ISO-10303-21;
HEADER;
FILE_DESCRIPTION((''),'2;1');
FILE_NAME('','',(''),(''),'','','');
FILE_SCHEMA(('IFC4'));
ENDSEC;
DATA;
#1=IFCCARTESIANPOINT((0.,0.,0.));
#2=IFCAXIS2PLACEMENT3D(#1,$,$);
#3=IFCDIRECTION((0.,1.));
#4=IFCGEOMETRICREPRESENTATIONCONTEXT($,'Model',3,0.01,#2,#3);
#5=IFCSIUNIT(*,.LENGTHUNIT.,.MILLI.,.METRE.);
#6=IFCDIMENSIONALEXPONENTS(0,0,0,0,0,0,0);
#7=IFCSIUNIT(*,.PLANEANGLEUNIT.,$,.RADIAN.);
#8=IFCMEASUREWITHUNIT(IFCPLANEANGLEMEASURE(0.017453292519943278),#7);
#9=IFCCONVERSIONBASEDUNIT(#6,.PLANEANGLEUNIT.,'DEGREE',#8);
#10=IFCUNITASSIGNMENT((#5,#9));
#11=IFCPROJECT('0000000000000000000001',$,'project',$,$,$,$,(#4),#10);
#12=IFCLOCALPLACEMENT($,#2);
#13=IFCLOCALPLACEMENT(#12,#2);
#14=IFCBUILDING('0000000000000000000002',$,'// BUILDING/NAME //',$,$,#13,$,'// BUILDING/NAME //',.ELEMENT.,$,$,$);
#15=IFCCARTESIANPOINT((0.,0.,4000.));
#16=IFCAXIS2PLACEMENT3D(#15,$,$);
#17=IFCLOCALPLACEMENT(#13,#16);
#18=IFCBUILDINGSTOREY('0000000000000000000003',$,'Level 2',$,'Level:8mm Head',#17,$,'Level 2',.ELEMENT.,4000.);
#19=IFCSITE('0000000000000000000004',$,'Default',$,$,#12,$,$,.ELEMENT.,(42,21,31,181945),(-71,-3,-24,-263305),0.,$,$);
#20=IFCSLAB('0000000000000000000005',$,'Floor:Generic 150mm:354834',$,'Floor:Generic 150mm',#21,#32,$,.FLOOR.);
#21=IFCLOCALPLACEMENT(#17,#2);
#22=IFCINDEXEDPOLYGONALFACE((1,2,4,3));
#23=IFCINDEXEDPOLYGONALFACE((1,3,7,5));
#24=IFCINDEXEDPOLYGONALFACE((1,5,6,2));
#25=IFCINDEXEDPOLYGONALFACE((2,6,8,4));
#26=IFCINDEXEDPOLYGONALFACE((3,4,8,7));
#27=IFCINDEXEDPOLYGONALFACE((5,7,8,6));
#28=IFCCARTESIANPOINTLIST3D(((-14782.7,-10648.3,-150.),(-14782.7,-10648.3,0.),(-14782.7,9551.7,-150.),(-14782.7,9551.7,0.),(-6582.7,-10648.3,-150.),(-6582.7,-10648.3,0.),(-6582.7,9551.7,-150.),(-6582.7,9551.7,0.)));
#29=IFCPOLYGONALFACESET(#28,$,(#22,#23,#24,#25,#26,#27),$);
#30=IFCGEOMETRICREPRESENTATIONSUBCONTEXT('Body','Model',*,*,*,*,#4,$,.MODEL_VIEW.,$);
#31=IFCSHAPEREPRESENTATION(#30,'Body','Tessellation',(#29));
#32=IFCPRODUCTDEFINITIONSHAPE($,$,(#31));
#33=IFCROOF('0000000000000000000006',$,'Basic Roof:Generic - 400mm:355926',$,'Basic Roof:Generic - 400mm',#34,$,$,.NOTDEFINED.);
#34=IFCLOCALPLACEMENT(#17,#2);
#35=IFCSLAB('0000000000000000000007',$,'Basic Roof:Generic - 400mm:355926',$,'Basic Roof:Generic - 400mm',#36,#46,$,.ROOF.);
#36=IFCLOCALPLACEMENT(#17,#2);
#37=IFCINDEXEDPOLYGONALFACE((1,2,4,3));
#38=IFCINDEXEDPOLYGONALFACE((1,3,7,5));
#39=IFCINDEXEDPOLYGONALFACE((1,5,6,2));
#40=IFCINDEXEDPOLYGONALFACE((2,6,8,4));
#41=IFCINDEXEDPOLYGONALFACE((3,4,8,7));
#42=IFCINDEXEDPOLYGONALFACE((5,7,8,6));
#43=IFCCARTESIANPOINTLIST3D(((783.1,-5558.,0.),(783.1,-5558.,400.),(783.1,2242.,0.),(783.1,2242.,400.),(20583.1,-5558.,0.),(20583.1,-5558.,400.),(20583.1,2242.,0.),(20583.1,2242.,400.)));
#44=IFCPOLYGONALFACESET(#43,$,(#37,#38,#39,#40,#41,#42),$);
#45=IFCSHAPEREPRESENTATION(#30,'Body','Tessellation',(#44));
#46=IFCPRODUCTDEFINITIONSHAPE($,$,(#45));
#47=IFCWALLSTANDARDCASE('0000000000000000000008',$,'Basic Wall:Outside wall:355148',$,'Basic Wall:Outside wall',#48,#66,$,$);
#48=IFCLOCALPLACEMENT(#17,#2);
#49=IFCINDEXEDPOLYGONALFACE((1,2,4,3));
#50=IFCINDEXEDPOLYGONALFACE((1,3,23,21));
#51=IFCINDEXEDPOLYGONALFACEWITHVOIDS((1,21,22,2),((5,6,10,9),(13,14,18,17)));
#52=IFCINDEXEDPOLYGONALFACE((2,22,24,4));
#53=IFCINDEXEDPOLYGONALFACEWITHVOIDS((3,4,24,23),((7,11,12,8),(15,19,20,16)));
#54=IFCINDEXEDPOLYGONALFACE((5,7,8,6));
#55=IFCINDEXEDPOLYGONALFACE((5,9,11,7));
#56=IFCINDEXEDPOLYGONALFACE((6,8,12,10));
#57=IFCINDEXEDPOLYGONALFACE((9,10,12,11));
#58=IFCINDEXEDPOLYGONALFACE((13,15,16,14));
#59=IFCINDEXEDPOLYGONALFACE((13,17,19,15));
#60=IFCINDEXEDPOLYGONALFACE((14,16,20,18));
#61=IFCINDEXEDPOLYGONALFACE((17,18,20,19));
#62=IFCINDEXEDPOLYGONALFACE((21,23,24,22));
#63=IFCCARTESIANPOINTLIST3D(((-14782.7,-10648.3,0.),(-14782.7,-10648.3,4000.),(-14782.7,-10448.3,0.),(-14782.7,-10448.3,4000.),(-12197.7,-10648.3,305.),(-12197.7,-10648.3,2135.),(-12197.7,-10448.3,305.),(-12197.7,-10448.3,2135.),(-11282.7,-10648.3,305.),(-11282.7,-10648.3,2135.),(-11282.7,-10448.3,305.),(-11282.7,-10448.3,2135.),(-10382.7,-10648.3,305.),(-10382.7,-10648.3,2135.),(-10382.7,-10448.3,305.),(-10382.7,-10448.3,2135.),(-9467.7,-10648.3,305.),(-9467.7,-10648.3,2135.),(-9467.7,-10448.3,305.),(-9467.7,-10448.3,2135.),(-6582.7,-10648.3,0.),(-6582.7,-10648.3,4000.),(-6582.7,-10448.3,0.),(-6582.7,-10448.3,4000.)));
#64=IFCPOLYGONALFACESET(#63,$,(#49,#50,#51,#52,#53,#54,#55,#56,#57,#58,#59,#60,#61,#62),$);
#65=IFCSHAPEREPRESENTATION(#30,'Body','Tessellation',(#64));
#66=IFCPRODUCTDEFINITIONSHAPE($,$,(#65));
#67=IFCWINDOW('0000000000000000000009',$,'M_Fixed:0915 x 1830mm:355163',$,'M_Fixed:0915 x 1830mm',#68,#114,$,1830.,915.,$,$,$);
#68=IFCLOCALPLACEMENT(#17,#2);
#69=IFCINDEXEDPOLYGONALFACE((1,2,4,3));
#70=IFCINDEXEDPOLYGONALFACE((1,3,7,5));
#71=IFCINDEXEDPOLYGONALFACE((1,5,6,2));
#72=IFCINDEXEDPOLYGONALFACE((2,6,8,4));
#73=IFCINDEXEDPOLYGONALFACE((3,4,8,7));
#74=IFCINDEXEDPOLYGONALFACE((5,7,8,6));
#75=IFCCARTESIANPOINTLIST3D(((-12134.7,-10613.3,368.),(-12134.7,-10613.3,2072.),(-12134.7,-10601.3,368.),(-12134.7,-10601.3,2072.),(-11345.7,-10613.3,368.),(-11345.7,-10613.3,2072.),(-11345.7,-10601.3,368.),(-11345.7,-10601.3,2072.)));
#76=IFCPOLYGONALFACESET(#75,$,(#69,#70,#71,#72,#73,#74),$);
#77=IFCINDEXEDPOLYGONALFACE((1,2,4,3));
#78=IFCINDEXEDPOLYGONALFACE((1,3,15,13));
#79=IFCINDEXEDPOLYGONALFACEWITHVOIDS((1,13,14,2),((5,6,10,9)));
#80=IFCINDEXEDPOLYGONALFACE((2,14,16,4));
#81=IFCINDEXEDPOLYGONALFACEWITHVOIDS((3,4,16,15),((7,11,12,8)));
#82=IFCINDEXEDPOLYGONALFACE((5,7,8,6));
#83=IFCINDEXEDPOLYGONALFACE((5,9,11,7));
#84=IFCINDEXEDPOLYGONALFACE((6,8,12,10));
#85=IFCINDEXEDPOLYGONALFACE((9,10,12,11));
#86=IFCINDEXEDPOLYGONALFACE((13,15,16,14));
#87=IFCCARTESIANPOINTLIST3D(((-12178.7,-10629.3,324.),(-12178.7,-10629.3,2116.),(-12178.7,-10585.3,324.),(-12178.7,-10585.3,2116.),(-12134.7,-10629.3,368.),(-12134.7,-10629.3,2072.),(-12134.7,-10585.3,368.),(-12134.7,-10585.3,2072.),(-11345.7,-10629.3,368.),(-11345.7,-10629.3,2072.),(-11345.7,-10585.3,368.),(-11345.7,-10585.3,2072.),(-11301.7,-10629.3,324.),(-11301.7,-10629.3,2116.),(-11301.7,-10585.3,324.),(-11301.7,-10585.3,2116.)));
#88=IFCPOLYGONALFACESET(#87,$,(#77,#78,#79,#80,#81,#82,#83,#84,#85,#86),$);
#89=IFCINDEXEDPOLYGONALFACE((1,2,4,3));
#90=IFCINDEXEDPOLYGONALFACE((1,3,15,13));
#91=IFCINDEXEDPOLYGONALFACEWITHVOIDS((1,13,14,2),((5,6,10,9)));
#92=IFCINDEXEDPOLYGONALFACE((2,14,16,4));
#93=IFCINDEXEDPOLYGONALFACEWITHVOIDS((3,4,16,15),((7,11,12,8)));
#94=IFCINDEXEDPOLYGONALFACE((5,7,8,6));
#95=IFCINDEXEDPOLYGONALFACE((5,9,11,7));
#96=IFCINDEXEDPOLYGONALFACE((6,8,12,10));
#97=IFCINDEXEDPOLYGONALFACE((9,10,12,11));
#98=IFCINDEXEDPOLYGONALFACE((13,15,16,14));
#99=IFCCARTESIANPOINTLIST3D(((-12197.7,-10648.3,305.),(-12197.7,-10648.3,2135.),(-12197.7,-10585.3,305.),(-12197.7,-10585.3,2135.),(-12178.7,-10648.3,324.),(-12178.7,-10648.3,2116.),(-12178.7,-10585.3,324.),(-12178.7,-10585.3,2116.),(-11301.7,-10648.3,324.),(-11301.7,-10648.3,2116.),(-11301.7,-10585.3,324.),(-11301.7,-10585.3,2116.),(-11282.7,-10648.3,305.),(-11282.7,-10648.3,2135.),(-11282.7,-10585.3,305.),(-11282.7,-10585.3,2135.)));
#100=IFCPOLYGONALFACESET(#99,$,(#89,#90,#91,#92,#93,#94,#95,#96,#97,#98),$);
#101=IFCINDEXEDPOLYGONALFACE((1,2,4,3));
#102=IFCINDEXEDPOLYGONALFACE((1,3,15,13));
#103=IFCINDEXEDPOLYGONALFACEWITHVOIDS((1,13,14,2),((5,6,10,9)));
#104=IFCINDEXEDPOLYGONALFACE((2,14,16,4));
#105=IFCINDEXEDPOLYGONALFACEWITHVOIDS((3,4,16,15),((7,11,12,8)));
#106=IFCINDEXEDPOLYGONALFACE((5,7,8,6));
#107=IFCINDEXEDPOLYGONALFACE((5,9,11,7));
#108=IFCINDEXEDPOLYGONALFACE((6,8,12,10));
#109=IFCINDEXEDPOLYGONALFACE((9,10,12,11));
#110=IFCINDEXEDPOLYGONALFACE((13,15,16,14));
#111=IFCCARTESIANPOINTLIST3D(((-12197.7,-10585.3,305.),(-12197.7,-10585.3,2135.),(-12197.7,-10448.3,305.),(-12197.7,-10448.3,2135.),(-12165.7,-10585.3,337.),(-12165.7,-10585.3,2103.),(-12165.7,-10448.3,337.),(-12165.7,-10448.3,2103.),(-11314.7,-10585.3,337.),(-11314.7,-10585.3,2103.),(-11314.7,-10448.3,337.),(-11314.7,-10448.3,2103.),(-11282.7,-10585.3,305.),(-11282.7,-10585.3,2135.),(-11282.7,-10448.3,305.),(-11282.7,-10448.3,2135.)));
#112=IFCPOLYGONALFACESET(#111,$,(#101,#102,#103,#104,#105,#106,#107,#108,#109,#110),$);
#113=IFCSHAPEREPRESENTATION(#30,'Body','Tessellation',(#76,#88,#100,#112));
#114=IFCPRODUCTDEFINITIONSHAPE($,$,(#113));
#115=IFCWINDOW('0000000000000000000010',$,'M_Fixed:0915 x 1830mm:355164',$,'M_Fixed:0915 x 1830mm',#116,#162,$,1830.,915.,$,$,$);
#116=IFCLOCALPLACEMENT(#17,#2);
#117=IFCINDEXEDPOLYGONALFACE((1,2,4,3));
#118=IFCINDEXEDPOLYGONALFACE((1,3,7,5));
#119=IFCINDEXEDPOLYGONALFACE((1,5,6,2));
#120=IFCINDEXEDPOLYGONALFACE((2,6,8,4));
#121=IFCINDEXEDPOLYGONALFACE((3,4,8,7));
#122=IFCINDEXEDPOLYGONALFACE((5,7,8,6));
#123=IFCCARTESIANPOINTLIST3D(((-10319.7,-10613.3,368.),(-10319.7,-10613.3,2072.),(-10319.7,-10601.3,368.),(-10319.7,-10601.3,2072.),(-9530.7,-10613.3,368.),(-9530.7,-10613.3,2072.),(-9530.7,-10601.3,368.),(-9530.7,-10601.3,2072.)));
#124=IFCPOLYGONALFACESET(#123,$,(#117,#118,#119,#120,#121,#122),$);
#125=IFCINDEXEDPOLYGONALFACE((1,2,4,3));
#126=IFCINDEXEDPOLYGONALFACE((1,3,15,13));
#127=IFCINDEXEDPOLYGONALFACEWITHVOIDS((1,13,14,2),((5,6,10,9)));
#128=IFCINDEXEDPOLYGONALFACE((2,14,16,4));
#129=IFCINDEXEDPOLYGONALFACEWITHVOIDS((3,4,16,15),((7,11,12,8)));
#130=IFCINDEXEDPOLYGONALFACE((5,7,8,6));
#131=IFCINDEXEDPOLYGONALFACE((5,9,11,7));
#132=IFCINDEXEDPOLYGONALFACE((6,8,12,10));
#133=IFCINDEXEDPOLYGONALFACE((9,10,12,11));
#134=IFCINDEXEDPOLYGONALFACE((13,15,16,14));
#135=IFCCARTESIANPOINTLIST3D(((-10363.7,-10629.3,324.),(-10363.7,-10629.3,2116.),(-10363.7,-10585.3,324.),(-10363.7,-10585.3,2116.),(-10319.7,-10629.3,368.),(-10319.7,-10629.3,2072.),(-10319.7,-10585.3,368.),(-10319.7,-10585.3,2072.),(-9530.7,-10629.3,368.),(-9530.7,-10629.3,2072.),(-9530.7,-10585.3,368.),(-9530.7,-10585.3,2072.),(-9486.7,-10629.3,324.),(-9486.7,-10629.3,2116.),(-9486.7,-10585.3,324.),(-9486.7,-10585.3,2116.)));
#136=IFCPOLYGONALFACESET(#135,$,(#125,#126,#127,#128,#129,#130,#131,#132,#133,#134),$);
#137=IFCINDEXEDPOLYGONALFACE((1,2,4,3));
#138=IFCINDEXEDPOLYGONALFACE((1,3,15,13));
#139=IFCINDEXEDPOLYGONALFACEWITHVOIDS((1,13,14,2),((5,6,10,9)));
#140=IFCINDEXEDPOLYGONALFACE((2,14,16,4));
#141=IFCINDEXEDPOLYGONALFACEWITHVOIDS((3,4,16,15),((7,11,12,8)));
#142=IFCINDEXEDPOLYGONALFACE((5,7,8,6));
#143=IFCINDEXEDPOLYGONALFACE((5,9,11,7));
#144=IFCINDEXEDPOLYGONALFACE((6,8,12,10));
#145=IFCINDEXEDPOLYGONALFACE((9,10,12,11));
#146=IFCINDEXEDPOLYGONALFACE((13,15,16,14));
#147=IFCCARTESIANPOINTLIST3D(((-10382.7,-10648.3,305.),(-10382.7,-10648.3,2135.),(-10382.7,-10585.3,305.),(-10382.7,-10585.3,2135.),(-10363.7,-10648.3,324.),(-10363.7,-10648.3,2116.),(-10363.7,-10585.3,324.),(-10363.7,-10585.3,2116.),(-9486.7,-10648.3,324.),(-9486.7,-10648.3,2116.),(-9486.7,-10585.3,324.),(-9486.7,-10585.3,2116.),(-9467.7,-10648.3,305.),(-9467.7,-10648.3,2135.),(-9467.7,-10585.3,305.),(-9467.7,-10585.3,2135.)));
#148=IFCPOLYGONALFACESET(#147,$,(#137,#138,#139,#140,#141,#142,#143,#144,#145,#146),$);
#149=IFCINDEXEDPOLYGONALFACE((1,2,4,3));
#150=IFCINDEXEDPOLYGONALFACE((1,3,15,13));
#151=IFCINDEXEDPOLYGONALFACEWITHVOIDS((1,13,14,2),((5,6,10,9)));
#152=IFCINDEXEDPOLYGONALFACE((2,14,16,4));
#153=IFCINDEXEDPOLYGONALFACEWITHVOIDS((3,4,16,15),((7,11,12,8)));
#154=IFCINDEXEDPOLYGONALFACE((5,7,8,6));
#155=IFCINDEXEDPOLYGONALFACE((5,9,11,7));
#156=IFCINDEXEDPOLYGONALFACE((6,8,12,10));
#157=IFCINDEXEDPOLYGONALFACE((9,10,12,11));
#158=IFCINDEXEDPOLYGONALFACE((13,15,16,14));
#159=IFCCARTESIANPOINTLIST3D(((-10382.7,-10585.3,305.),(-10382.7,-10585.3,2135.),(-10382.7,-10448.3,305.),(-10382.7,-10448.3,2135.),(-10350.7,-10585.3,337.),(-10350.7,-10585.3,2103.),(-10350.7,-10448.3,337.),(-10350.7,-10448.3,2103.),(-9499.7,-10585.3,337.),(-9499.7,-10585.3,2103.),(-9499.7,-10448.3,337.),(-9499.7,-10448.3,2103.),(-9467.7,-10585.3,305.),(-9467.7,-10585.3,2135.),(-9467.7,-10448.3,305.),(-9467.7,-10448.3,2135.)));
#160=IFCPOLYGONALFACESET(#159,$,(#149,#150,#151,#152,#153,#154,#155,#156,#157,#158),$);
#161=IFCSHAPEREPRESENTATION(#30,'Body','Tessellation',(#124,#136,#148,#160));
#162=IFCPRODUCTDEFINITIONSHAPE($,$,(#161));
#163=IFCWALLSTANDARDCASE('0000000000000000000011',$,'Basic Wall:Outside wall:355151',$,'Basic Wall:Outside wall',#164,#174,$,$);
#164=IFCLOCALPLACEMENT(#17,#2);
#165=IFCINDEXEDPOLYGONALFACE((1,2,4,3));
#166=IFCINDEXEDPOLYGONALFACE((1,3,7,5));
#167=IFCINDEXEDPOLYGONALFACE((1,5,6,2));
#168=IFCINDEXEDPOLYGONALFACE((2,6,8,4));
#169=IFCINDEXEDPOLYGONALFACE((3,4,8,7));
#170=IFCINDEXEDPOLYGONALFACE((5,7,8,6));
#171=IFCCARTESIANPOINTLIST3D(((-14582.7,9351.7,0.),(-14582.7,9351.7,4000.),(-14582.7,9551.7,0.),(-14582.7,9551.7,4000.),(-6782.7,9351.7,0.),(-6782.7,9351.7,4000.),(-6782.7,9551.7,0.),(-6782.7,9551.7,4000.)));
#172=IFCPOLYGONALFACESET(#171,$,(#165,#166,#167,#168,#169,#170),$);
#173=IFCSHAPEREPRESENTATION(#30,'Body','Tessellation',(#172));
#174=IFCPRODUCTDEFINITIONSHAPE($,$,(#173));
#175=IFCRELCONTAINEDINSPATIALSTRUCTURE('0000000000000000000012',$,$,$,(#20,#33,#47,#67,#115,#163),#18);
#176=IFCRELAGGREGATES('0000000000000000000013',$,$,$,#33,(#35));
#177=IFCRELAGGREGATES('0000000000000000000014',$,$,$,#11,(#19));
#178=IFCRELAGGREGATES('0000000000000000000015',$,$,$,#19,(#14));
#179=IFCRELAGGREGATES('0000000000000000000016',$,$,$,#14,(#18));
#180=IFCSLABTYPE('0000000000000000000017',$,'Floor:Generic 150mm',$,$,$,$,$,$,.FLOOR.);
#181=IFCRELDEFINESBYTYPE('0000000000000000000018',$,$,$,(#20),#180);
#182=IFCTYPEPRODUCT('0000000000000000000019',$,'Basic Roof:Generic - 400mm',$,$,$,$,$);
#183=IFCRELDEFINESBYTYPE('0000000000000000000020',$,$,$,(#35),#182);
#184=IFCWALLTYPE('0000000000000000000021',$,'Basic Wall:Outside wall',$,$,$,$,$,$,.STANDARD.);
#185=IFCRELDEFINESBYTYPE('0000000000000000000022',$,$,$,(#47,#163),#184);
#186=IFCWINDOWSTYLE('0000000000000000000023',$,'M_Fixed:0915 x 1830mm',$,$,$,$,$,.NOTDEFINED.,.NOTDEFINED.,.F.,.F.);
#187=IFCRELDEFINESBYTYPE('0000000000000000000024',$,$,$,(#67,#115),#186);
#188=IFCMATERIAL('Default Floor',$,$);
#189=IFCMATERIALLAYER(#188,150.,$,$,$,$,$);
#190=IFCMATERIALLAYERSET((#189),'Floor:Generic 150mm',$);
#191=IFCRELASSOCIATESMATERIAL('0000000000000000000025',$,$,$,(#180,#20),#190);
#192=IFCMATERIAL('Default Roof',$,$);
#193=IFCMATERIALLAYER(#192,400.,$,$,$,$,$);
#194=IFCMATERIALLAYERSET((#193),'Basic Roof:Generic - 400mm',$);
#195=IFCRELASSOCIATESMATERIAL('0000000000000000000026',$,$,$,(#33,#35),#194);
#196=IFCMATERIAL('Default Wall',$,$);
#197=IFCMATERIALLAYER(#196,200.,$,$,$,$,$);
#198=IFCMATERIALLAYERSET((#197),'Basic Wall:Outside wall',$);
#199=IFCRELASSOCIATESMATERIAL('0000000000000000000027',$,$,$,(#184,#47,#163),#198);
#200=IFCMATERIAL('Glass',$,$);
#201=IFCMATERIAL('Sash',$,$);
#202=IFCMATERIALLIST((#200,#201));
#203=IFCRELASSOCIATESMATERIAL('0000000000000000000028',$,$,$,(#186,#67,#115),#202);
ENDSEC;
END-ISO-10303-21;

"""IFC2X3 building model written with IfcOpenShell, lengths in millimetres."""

from ifc_helpers import new_model, entity, si_unit, converted_unit, direction, frame, frame_2d, origin, place, context, subcontext, project, spatial, polyline, rectangle, outline, extrude, source, transform, mapped, material, material_list, layer, layer_set, layer_usage, type_object, type_shapes, element, fill, aggregate, save


model = new_model("IFC2X3")

# Units and contexts
model_context = context("Model", 3, precision=0.01, world=origin(), true_north=direction((0.0, 1.0)))
body_context = subcontext(model_context, "Body", "Model", "MODEL_VIEW")
ifc_project = project(units=[si_unit("LENGTHUNIT", "METRE", prefix="MILLI"), converted_unit("PLANEANGLEUNIT", "DEGREE", entity("IfcPlaneAngleMeasure", 0.017453292519943278), si_unit("PLANEANGLEUNIT", "RADIAN"), dimensions=[0, 0, 0, 0, 0, 0, 0])], contexts=[model_context])

# Site, building, storey
site_placement = place(None, origin())
site = spatial("IfcSite", under=ifc_project, at=site_placement, Name="Default", CompositionType="ELEMENT", RefLatitude=(42, 21, 31, 181945), RefLongitude=(-71, -3, -24, -263305), RefElevation=0.0)
building_placement = place(site_placement, origin())
building = spatial("IfcBuilding", under=site, at=building_placement, Name="// BUILDING/NAME //", LongName="// BUILDING/NAME //", CompositionType="ELEMENT")
storey_placement = place(building_placement, frame((0.0, 0.0, 4000.0)))
storey = spatial("IfcBuildingStorey", under=building, at=storey_placement, Name="Level 2", ObjectType="Level:8mm Head", LongName="Level 2", CompositionType="ELEMENT", Elevation=4000.0)

# Slab
ifc_material_1 = material(Name="Default Floor")
ifc_layer_1 = layer(ifc_material_1, 150.0)
ifc_layer_set_1 = layer_set([ifc_layer_1], Name="Floor:Generic 150mm")
ifc_layer_usage_1 = layer_usage(ifc_layer_set_1, "AXIS3", "POSITIVE", 0.0)
slab_type = type_object("IfcSlabType", Name="Floor:Generic 150mm", PredefinedType="FLOOR", material=ifc_layer_set_1)
slab_1_placement = place(storey_placement, origin())
element("IfcSlab", 1, at=slab_1_placement, inside=storey, type_object=slab_type, material=ifc_layer_usage_1, Name="Floor:Generic 150mm:354834", ObjectType="Floor:Generic 150mm", PredefinedType="FLOOR", context=body_context, shape_type="SweptSolid", body=[
    extrude(rectangle(XDim=20200.0, YDim=8200.0, at=frame_2d((0.0, 0.0), x_axis=(1.0, 0.0))), frame((-10682.7, -548.3, 0.0), z_axis=(0.0, 0.0, -1.0), x_axis=(0.0, 1.0, 0.0)), (0.0, 0.0, 1.0), 150.0),
])

# Roof, slab
ifc_material_2 = material(Name="Default Roof")
ifc_layer_2 = layer(ifc_material_2, 400.0)
ifc_layer_set_2 = layer_set([ifc_layer_2], Name="Basic Roof:Generic - 400mm")
roof_placement = place(storey_placement, frame((783.1, -5558.0, 0.0)))
roof = element("IfcRoof", 2, at=roof_placement, inside=storey, material=ifc_layer_set_2, Name="Basic Roof:Generic - 400mm:355926", ObjectType="Basic Roof:Generic - 400mm", ShapeType="NOTDEFINED")
type_product = type_object("IfcTypeProduct", Name="Basic Roof:Generic - 400mm")
slab_2_placement = place(roof_placement, origin())
slab_2 = element("IfcSlab", 3, at=slab_2_placement, type_object=type_product, material=ifc_layer_set_2, Name="Basic Roof:Generic - 400mm:355926", ObjectType="Basic Roof:Generic - 400mm", PredefinedType="ROOF", context=body_context, shape_type="SweptSolid", body=[
    extrude(rectangle(XDim=7800.0, YDim=19800.0, at=frame_2d((0.0, 0.0), x_axis=(0.0, 1.0))), frame((9900.0, 3900.0, 0.0)), (0.0, 0.0, 1.0), 400.0),
])
aggregate(roof, [slab_2])

# Wall, openings, windows
ifc_material_3 = material(Name="Default Wall")
ifc_layer_3 = layer(ifc_material_3, 200.0)
ifc_layer_set_3 = layer_set([ifc_layer_3], Name="Basic Wall:Outside wall")
ifc_layer_usage_2 = layer_usage(ifc_layer_set_3, "AXIS2", "NEGATIVE", 100.0)
wall_type = type_object("IfcWallType", Name="Basic Wall:Outside wall", PredefinedType="STANDARD", material=ifc_layer_set_3)
wall_1_placement = place(storey_placement, frame((-14782.7, -10548.3, 0.0)))
wall_1 = element("IfcWallStandardCase", 4, at=wall_1_placement, inside=storey, type_object=wall_type, material=ifc_layer_usage_2, Name="Basic Wall:Outside wall:355148", ObjectType="Basic Wall:Outside wall", context=body_context, shape_type="SweptSolid", body=[
    extrude(rectangle(XDim=8200.0, YDim=200.0, at=frame_2d((4100.0, 0.0), x_axis=(-1.0, 0.0))), origin(), (0.0, 0.0, 1.0), 4000.0),
])
opening_1_placement = place(wall_1_placement, frame((3500.0, 100.0, 305.0)))
opening_1 = element("IfcOpeningElement", 5, at=opening_1_placement, cuts=wall_1, ObjectType="Opening", context=body_context, shape_type="SweptSolid", body=[
    extrude(rectangle(XDim=1830.0, YDim=915.0, at=frame_2d((915.0, 457.5), x_axis=(1.0, 0.0))), frame((0.0, 0.0, 0.0), z_axis=(0.0, -1.0, 0.0), x_axis=(0.0, 0.0, 1.0)), (0.0, 0.0, 1.0), 200.0),
])
opening_2_placement = place(wall_1_placement, frame((5315.0, 100.0, 305.0)))
opening_2 = element("IfcOpeningElement", 6, at=opening_2_placement, cuts=wall_1, ObjectType="Opening", context=body_context, shape_type="SweptSolid", body=[
    extrude(rectangle(XDim=1830.0, YDim=915.0, at=frame_2d((915.0, 457.5), x_axis=(1.0, 0.0))), frame((0.0, 0.0, 0.0), z_axis=(0.0, -1.0, 0.0), x_axis=(0.0, 0.0, 1.0)), (0.0, 0.0, 1.0), 200.0),
])
ifc_material_4 = material(Name="Glass")
ifc_material_5 = material(Name="Sash")
ifc_material_list = material_list([ifc_material_4, ifc_material_5])
window_style = type_object("IfcWindowStyle", Name="M_Fixed:0915 x 1830mm", ConstructionType="NOTDEFINED", OperationType="NOTDEFINED", ParameterTakesPrecedence=False, Sizeable=False, material=ifc_material_list)
shared_shape = source(origin(), body_context, "Body", "SweptSolid", [
    extrude(rectangle(XDim=12.0, YDim=789.0, at=frame_2d((0.0, 0.0), x_axis=(1.0, 0.0))), frame((457.5, 159.0, 63.0), z_axis=(0.0, 0.0, 1.0), x_axis=(0.0, -1.0, 0.0)), (0.0, 0.0, 1.0), 1704.0),
    extrude(outline(polyline([(-438.5, -896.0), (438.5, -896.0), (438.5, 896.0), (-438.5, 896.0), (-438.5, -896.0)]), holes=[polyline([(-394.5, -852.0), (-394.5, 852.0), (394.5, 852.0), (394.5, -852.0), (-394.5, -852.0)])]), frame((457.5, 137.0, 915.0), z_axis=(0.0, 1.0, 0.0), x_axis=(1.0, 0.0, 0.0)), (0.0, 0.0, 1.0), 44.0),
    extrude(outline(polyline([(-457.5, -915.0), (457.5, -915.0), (457.5, 915.0), (-457.5, 915.0), (-457.5, -915.0)]), holes=[polyline([(-438.5, -896.0), (-438.5, 896.0), (438.5, 896.0), (438.5, -896.0), (-438.5, -896.0)])]), frame((457.5, 137.0, 915.0), z_axis=(0.0, 1.0, 0.0), x_axis=(1.0, 0.0, 0.0)), (0.0, 0.0, 1.0), 63.0),
    extrude(outline(polyline([(-457.5, -915.0), (457.5, -915.0), (457.5, 915.0), (-457.5, 915.0), (-457.5, -915.0)]), holes=[polyline([(-425.5, -883.0), (-425.5, 883.0), (425.5, 883.0), (425.5, -883.0), (-425.5, -883.0)])]), frame((457.5, 0.0, 915.0), z_axis=(0.0, 1.0, 0.0), x_axis=(1.0, 0.0, 0.0)), (0.0, 0.0, 1.0), 137.0),
])
type_shapes(window_style, [shared_shape])
window_1_placement = place(opening_1_placement, frame((0.0, 0.0, 0.0), z_axis=(0.0, 0.0, 1.0), x_axis=(-1.0, 0.0, 0.0)))
window_1 = element("IfcWindow", 7, at=window_1_placement, inside=storey, type_object=window_style, material=ifc_material_list, Name="M_Fixed:0915 x 1830mm:355163", ObjectType="M_Fixed:0915 x 1830mm", OverallHeight=1830.0, OverallWidth=915.0, context=body_context, shape_type="MappedRepresentation", body=[
    mapped(shared_shape, transform((0.0, 0.0, 0.0), scale=1.0)),
])
fill(opening_1, window_1)
window_2_placement = place(opening_2_placement, frame((0.0, 0.0, 0.0), z_axis=(0.0, 0.0, 1.0), x_axis=(-1.0, 0.0, 0.0)))
window_2 = element("IfcWindow", 8, at=window_2_placement, inside=storey, type_object=window_style, material=ifc_material_list, Name="M_Fixed:0915 x 1830mm:355164", ObjectType="M_Fixed:0915 x 1830mm", OverallHeight=1830.0, OverallWidth=915.0, context=body_context, shape_type="MappedRepresentation", body=[
    mapped(shared_shape, transform((0.0, 0.0, 0.0), scale=1.0)),
])
fill(opening_2, window_2)

# Wall
wall_2_placement = place(storey_placement, frame((-6782.7, 9451.7, 0.0), z_axis=(0.0, 0.0, 1.0), x_axis=(-1.0, 0.0, 0.0)))
element("IfcWallStandardCase", 9, at=wall_2_placement, inside=storey, type_object=wall_type, material=ifc_layer_usage_2, Name="Basic Wall:Outside wall:355151", ObjectType="Basic Wall:Outside wall", context=body_context, shape_type="SweptSolid", body=[
    extrude(rectangle(XDim=7800.0, YDim=200.0, at=frame_2d((3900.0, 0.0), x_axis=(-1.0, 0.0))), origin(), (0.0, 0.0, 1.0), 4000.0),
])

save(model, "model.ifc")
